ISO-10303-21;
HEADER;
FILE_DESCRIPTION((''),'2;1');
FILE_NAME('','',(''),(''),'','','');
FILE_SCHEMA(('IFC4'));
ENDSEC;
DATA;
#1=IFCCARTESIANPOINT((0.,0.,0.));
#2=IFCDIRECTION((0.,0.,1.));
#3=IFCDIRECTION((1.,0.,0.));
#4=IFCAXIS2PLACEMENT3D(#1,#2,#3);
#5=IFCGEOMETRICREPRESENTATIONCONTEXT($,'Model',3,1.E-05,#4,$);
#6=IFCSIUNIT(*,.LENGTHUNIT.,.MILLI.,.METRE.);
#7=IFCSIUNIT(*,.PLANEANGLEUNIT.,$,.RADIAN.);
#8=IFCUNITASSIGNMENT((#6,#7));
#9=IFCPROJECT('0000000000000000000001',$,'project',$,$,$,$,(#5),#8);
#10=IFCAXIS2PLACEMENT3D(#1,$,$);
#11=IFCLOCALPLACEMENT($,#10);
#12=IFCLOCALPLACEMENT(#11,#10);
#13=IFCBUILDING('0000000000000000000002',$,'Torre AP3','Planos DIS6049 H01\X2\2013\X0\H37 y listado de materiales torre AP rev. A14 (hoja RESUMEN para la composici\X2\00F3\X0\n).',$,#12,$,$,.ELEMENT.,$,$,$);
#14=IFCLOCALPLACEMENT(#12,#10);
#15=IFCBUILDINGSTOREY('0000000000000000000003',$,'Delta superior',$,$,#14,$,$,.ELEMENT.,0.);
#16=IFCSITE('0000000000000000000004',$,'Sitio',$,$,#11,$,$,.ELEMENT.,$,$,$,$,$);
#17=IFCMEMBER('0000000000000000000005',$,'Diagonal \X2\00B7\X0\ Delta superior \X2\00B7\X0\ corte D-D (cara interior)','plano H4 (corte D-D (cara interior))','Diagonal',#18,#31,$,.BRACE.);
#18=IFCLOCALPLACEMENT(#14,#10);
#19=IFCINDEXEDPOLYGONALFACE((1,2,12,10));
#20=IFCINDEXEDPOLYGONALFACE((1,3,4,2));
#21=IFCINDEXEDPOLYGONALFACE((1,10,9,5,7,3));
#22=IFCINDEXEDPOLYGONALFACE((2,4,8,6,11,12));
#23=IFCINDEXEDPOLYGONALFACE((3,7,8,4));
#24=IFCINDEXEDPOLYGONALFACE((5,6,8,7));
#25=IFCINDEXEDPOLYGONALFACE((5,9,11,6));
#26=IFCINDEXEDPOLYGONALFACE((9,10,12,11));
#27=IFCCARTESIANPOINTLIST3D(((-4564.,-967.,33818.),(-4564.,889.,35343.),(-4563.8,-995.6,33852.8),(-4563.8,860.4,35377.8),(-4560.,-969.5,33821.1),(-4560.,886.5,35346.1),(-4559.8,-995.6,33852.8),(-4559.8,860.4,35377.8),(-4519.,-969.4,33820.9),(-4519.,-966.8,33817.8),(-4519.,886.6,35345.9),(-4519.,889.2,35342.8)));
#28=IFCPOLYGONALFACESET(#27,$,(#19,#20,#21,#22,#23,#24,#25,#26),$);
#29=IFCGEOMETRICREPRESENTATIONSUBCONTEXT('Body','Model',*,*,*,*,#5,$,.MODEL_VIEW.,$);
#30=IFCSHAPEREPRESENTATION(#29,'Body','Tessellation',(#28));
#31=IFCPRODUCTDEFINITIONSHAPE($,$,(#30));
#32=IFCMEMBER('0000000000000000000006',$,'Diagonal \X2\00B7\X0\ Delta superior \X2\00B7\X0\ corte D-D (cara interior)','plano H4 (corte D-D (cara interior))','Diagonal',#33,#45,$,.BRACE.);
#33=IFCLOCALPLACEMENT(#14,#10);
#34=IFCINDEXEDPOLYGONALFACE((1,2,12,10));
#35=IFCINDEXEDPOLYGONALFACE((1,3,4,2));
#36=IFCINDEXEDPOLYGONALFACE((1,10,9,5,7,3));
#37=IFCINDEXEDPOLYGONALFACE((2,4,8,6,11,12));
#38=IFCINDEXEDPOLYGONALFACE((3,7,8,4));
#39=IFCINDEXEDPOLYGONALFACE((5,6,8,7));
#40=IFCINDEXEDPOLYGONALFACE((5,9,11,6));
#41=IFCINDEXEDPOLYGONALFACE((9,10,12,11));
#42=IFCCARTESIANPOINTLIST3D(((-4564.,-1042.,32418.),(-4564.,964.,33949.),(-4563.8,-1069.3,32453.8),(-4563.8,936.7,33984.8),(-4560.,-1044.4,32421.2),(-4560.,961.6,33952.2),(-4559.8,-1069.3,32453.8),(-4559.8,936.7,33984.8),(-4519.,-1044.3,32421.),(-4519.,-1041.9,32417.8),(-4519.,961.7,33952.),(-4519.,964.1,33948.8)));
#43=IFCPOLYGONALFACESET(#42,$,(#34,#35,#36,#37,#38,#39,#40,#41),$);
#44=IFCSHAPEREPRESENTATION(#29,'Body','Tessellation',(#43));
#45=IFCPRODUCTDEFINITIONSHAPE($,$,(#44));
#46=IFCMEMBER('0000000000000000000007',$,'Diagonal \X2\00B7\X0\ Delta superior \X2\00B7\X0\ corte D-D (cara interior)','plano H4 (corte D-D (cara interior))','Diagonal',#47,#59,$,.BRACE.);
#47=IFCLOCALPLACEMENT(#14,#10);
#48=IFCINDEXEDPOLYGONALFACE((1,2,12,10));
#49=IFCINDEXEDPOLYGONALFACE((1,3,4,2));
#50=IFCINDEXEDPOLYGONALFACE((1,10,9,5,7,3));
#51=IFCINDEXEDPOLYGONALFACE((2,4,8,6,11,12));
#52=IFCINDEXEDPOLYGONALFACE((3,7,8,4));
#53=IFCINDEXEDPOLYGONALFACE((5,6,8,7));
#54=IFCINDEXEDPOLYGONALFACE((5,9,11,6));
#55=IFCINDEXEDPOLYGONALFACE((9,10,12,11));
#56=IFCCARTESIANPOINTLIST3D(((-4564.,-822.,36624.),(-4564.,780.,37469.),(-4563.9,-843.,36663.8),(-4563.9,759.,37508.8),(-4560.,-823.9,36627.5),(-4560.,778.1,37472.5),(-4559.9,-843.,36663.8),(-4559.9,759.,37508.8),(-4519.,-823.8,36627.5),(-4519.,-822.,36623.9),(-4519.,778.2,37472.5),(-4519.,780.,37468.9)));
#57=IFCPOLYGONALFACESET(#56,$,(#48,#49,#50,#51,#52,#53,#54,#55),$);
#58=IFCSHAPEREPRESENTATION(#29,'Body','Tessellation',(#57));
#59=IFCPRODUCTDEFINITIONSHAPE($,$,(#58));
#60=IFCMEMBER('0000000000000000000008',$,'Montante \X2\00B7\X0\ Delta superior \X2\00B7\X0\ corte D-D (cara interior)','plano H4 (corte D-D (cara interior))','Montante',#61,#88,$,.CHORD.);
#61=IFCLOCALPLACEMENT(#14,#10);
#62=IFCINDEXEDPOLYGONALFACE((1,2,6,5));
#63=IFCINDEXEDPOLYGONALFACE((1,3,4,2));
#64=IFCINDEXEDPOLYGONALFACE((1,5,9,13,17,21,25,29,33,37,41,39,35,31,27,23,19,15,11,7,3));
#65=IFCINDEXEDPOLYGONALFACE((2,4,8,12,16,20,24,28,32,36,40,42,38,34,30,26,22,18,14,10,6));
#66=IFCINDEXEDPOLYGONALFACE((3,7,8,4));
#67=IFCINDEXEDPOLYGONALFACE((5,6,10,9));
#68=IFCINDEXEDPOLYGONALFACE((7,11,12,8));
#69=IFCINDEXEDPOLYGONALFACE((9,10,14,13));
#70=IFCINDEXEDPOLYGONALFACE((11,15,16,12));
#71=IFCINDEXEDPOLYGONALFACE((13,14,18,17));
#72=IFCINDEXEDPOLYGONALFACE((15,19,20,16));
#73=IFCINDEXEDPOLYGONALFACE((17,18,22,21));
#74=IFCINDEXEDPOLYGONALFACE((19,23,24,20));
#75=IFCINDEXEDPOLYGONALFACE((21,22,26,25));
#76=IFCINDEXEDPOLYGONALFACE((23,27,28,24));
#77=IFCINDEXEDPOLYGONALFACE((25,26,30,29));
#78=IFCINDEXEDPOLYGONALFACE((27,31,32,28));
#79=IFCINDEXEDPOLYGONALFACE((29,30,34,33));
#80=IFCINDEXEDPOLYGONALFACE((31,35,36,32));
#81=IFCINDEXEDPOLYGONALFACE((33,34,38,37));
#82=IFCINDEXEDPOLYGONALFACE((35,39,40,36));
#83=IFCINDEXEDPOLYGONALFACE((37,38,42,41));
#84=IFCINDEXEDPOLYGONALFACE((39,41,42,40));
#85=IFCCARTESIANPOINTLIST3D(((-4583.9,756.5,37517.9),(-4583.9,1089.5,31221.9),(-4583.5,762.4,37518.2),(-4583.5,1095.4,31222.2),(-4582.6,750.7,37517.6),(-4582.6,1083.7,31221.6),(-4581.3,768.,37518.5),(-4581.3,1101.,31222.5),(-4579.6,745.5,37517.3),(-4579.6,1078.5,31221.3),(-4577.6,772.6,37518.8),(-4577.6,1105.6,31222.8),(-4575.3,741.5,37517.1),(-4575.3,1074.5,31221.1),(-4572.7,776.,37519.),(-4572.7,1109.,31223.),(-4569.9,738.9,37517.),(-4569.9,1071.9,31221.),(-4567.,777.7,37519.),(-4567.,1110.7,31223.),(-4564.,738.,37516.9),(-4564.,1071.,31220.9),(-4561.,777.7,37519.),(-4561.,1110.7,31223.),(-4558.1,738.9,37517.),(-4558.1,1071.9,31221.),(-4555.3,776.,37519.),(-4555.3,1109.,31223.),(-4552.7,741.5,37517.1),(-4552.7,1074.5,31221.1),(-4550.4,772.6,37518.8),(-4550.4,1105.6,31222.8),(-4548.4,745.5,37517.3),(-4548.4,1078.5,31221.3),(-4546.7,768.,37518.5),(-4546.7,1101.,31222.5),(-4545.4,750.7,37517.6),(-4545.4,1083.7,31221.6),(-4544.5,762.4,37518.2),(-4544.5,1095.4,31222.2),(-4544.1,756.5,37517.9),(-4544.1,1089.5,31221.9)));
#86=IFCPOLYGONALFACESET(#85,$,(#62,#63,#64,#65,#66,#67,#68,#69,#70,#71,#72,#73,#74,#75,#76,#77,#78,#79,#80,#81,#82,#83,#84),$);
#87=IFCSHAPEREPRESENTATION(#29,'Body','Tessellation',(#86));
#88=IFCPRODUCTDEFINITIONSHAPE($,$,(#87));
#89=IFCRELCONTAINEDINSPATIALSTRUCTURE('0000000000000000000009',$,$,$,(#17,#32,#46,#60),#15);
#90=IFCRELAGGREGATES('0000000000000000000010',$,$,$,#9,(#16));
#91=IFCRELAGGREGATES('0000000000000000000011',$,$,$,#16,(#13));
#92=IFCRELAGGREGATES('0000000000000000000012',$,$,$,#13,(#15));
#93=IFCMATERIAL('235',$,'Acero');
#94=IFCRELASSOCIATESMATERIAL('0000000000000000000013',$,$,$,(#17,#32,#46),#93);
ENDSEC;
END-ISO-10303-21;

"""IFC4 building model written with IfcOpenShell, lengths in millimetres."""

from ifc_helpers import new_model, si_unit, frame, frame_2d, origin, origin_with_axes, place, context, subcontext, project, spatial, circle, l_section, extrude, material, element, save


model = new_model("IFC4")

# Units and contexts
model_context = context("Model", 3, precision=1e-05, world=origin_with_axes())
body_context = subcontext(model_context, "Body", "Model", "MODEL_VIEW")
ifc_project = project(units=[si_unit("LENGTHUNIT", "METRE", prefix="MILLI"), si_unit("PLANEANGLEUNIT", "RADIAN")], contexts=[model_context])

# Site, building, storey
site_placement = place(None, origin())
site = spatial("IfcSite", under=ifc_project, at=site_placement, Name="Sitio", CompositionType="ELEMENT")
building_placement = place(site_placement, origin())
building = spatial("IfcBuilding", under=site, at=building_placement, Name="Torre AP3", Description="Planos DIS6049 H01–H37 y listado de materiales torre AP rev. A14 (hoja RESUMEN para la composición).", CompositionType="ELEMENT")
storey_placement = place(building_placement, origin())
storey = spatial("IfcBuildingStorey", under=building, at=storey_placement, Name="Delta superior", CompositionType="ELEMENT", Elevation=0.0)

# Members
ifc_material_1 = material(Name="235", Category="Acero")
member_1_placement = place(storey_placement, frame((-4564.0, 889.0, 35343.0), z_axis=(0.0, -0.772639, -0.634846), x_axis=(0.999985, 0.003444, -0.004191)))
element("IfcMember", 1, at=member_1_placement, inside=storey, material=ifc_material_1, Name="Diagonal · Delta superior · corte D-D (cara interior)", Description="plano H4 (corte D-D (cara interior))", ObjectType="Diagonal", PredefinedType="BRACE", context=body_context, shape_type="SweptSolid", body=[
    extrude(l_section(Depth=45.0, Width=45.0, Thickness=4.0, at=frame_2d((22.5, 22.5))), None, (0.0, 0.0, 1.0), 2402.2),
])
member_2_placement = place(storey_placement, frame((-4564.0, 964.0, 33949.0), z_axis=(0.0, -0.794931, -0.6067), x_axis=(0.999987, 0.003145, -0.004121)))
element("IfcMember", 2, at=member_2_placement, inside=storey, material=ifc_material_1, Name="Diagonal · Delta superior · corte D-D (cara interior)", Description="plano H4 (corte D-D (cara interior))", ObjectType="Diagonal", PredefinedType="BRACE", context=body_context, shape_type="SweptSolid", body=[
    extrude(l_section(Depth=45.0, Width=45.0, Thickness=4.0, at=frame_2d((22.5, 22.5))), None, (0.0, 0.0, 1.0), 2523.5),
])
member_3_placement = place(storey_placement, frame((-4564.0, 780.0, 37469.0), z_axis=(0.0, -0.884499, -0.466543), x_axis=(0.999998, 0.001002, -0.001899)))
element("IfcMember", 3, at=member_3_placement, inside=storey, material=ifc_material_1, Name="Diagonal · Delta superior · corte D-D (cara interior)", Description="plano H4 (corte D-D (cara interior))", ObjectType="Diagonal", PredefinedType="BRACE", context=body_context, shape_type="SweptSolid", body=[
    extrude(l_section(Depth=45.0, Width=45.0, Thickness=4.0, at=frame_2d((22.5, 22.5))), None, (0.0, 0.0, 1.0), 1811.2),
])
member_4_placement = place(storey_placement, frame((-4564.0, 1091.0, 31222.0), z_axis=(0.0, -0.052817, 0.998604), x_axis=(0.0, -0.998604, -0.052817)))
element("IfcMember", 4, at=member_4_placement, inside=storey, Name="Montante · Delta superior · corte D-D (cara interior)", Description="plano H4 (corte D-D (cara interior))", ObjectType="Montante", PredefinedType="CHORD", context=body_context, shape_type="SweptSolid", body=[
    extrude(circle(Radius=20.0), None, (0.0, 0.0, 1.0), 6304.8),
])

save(model, "model.ifc")
